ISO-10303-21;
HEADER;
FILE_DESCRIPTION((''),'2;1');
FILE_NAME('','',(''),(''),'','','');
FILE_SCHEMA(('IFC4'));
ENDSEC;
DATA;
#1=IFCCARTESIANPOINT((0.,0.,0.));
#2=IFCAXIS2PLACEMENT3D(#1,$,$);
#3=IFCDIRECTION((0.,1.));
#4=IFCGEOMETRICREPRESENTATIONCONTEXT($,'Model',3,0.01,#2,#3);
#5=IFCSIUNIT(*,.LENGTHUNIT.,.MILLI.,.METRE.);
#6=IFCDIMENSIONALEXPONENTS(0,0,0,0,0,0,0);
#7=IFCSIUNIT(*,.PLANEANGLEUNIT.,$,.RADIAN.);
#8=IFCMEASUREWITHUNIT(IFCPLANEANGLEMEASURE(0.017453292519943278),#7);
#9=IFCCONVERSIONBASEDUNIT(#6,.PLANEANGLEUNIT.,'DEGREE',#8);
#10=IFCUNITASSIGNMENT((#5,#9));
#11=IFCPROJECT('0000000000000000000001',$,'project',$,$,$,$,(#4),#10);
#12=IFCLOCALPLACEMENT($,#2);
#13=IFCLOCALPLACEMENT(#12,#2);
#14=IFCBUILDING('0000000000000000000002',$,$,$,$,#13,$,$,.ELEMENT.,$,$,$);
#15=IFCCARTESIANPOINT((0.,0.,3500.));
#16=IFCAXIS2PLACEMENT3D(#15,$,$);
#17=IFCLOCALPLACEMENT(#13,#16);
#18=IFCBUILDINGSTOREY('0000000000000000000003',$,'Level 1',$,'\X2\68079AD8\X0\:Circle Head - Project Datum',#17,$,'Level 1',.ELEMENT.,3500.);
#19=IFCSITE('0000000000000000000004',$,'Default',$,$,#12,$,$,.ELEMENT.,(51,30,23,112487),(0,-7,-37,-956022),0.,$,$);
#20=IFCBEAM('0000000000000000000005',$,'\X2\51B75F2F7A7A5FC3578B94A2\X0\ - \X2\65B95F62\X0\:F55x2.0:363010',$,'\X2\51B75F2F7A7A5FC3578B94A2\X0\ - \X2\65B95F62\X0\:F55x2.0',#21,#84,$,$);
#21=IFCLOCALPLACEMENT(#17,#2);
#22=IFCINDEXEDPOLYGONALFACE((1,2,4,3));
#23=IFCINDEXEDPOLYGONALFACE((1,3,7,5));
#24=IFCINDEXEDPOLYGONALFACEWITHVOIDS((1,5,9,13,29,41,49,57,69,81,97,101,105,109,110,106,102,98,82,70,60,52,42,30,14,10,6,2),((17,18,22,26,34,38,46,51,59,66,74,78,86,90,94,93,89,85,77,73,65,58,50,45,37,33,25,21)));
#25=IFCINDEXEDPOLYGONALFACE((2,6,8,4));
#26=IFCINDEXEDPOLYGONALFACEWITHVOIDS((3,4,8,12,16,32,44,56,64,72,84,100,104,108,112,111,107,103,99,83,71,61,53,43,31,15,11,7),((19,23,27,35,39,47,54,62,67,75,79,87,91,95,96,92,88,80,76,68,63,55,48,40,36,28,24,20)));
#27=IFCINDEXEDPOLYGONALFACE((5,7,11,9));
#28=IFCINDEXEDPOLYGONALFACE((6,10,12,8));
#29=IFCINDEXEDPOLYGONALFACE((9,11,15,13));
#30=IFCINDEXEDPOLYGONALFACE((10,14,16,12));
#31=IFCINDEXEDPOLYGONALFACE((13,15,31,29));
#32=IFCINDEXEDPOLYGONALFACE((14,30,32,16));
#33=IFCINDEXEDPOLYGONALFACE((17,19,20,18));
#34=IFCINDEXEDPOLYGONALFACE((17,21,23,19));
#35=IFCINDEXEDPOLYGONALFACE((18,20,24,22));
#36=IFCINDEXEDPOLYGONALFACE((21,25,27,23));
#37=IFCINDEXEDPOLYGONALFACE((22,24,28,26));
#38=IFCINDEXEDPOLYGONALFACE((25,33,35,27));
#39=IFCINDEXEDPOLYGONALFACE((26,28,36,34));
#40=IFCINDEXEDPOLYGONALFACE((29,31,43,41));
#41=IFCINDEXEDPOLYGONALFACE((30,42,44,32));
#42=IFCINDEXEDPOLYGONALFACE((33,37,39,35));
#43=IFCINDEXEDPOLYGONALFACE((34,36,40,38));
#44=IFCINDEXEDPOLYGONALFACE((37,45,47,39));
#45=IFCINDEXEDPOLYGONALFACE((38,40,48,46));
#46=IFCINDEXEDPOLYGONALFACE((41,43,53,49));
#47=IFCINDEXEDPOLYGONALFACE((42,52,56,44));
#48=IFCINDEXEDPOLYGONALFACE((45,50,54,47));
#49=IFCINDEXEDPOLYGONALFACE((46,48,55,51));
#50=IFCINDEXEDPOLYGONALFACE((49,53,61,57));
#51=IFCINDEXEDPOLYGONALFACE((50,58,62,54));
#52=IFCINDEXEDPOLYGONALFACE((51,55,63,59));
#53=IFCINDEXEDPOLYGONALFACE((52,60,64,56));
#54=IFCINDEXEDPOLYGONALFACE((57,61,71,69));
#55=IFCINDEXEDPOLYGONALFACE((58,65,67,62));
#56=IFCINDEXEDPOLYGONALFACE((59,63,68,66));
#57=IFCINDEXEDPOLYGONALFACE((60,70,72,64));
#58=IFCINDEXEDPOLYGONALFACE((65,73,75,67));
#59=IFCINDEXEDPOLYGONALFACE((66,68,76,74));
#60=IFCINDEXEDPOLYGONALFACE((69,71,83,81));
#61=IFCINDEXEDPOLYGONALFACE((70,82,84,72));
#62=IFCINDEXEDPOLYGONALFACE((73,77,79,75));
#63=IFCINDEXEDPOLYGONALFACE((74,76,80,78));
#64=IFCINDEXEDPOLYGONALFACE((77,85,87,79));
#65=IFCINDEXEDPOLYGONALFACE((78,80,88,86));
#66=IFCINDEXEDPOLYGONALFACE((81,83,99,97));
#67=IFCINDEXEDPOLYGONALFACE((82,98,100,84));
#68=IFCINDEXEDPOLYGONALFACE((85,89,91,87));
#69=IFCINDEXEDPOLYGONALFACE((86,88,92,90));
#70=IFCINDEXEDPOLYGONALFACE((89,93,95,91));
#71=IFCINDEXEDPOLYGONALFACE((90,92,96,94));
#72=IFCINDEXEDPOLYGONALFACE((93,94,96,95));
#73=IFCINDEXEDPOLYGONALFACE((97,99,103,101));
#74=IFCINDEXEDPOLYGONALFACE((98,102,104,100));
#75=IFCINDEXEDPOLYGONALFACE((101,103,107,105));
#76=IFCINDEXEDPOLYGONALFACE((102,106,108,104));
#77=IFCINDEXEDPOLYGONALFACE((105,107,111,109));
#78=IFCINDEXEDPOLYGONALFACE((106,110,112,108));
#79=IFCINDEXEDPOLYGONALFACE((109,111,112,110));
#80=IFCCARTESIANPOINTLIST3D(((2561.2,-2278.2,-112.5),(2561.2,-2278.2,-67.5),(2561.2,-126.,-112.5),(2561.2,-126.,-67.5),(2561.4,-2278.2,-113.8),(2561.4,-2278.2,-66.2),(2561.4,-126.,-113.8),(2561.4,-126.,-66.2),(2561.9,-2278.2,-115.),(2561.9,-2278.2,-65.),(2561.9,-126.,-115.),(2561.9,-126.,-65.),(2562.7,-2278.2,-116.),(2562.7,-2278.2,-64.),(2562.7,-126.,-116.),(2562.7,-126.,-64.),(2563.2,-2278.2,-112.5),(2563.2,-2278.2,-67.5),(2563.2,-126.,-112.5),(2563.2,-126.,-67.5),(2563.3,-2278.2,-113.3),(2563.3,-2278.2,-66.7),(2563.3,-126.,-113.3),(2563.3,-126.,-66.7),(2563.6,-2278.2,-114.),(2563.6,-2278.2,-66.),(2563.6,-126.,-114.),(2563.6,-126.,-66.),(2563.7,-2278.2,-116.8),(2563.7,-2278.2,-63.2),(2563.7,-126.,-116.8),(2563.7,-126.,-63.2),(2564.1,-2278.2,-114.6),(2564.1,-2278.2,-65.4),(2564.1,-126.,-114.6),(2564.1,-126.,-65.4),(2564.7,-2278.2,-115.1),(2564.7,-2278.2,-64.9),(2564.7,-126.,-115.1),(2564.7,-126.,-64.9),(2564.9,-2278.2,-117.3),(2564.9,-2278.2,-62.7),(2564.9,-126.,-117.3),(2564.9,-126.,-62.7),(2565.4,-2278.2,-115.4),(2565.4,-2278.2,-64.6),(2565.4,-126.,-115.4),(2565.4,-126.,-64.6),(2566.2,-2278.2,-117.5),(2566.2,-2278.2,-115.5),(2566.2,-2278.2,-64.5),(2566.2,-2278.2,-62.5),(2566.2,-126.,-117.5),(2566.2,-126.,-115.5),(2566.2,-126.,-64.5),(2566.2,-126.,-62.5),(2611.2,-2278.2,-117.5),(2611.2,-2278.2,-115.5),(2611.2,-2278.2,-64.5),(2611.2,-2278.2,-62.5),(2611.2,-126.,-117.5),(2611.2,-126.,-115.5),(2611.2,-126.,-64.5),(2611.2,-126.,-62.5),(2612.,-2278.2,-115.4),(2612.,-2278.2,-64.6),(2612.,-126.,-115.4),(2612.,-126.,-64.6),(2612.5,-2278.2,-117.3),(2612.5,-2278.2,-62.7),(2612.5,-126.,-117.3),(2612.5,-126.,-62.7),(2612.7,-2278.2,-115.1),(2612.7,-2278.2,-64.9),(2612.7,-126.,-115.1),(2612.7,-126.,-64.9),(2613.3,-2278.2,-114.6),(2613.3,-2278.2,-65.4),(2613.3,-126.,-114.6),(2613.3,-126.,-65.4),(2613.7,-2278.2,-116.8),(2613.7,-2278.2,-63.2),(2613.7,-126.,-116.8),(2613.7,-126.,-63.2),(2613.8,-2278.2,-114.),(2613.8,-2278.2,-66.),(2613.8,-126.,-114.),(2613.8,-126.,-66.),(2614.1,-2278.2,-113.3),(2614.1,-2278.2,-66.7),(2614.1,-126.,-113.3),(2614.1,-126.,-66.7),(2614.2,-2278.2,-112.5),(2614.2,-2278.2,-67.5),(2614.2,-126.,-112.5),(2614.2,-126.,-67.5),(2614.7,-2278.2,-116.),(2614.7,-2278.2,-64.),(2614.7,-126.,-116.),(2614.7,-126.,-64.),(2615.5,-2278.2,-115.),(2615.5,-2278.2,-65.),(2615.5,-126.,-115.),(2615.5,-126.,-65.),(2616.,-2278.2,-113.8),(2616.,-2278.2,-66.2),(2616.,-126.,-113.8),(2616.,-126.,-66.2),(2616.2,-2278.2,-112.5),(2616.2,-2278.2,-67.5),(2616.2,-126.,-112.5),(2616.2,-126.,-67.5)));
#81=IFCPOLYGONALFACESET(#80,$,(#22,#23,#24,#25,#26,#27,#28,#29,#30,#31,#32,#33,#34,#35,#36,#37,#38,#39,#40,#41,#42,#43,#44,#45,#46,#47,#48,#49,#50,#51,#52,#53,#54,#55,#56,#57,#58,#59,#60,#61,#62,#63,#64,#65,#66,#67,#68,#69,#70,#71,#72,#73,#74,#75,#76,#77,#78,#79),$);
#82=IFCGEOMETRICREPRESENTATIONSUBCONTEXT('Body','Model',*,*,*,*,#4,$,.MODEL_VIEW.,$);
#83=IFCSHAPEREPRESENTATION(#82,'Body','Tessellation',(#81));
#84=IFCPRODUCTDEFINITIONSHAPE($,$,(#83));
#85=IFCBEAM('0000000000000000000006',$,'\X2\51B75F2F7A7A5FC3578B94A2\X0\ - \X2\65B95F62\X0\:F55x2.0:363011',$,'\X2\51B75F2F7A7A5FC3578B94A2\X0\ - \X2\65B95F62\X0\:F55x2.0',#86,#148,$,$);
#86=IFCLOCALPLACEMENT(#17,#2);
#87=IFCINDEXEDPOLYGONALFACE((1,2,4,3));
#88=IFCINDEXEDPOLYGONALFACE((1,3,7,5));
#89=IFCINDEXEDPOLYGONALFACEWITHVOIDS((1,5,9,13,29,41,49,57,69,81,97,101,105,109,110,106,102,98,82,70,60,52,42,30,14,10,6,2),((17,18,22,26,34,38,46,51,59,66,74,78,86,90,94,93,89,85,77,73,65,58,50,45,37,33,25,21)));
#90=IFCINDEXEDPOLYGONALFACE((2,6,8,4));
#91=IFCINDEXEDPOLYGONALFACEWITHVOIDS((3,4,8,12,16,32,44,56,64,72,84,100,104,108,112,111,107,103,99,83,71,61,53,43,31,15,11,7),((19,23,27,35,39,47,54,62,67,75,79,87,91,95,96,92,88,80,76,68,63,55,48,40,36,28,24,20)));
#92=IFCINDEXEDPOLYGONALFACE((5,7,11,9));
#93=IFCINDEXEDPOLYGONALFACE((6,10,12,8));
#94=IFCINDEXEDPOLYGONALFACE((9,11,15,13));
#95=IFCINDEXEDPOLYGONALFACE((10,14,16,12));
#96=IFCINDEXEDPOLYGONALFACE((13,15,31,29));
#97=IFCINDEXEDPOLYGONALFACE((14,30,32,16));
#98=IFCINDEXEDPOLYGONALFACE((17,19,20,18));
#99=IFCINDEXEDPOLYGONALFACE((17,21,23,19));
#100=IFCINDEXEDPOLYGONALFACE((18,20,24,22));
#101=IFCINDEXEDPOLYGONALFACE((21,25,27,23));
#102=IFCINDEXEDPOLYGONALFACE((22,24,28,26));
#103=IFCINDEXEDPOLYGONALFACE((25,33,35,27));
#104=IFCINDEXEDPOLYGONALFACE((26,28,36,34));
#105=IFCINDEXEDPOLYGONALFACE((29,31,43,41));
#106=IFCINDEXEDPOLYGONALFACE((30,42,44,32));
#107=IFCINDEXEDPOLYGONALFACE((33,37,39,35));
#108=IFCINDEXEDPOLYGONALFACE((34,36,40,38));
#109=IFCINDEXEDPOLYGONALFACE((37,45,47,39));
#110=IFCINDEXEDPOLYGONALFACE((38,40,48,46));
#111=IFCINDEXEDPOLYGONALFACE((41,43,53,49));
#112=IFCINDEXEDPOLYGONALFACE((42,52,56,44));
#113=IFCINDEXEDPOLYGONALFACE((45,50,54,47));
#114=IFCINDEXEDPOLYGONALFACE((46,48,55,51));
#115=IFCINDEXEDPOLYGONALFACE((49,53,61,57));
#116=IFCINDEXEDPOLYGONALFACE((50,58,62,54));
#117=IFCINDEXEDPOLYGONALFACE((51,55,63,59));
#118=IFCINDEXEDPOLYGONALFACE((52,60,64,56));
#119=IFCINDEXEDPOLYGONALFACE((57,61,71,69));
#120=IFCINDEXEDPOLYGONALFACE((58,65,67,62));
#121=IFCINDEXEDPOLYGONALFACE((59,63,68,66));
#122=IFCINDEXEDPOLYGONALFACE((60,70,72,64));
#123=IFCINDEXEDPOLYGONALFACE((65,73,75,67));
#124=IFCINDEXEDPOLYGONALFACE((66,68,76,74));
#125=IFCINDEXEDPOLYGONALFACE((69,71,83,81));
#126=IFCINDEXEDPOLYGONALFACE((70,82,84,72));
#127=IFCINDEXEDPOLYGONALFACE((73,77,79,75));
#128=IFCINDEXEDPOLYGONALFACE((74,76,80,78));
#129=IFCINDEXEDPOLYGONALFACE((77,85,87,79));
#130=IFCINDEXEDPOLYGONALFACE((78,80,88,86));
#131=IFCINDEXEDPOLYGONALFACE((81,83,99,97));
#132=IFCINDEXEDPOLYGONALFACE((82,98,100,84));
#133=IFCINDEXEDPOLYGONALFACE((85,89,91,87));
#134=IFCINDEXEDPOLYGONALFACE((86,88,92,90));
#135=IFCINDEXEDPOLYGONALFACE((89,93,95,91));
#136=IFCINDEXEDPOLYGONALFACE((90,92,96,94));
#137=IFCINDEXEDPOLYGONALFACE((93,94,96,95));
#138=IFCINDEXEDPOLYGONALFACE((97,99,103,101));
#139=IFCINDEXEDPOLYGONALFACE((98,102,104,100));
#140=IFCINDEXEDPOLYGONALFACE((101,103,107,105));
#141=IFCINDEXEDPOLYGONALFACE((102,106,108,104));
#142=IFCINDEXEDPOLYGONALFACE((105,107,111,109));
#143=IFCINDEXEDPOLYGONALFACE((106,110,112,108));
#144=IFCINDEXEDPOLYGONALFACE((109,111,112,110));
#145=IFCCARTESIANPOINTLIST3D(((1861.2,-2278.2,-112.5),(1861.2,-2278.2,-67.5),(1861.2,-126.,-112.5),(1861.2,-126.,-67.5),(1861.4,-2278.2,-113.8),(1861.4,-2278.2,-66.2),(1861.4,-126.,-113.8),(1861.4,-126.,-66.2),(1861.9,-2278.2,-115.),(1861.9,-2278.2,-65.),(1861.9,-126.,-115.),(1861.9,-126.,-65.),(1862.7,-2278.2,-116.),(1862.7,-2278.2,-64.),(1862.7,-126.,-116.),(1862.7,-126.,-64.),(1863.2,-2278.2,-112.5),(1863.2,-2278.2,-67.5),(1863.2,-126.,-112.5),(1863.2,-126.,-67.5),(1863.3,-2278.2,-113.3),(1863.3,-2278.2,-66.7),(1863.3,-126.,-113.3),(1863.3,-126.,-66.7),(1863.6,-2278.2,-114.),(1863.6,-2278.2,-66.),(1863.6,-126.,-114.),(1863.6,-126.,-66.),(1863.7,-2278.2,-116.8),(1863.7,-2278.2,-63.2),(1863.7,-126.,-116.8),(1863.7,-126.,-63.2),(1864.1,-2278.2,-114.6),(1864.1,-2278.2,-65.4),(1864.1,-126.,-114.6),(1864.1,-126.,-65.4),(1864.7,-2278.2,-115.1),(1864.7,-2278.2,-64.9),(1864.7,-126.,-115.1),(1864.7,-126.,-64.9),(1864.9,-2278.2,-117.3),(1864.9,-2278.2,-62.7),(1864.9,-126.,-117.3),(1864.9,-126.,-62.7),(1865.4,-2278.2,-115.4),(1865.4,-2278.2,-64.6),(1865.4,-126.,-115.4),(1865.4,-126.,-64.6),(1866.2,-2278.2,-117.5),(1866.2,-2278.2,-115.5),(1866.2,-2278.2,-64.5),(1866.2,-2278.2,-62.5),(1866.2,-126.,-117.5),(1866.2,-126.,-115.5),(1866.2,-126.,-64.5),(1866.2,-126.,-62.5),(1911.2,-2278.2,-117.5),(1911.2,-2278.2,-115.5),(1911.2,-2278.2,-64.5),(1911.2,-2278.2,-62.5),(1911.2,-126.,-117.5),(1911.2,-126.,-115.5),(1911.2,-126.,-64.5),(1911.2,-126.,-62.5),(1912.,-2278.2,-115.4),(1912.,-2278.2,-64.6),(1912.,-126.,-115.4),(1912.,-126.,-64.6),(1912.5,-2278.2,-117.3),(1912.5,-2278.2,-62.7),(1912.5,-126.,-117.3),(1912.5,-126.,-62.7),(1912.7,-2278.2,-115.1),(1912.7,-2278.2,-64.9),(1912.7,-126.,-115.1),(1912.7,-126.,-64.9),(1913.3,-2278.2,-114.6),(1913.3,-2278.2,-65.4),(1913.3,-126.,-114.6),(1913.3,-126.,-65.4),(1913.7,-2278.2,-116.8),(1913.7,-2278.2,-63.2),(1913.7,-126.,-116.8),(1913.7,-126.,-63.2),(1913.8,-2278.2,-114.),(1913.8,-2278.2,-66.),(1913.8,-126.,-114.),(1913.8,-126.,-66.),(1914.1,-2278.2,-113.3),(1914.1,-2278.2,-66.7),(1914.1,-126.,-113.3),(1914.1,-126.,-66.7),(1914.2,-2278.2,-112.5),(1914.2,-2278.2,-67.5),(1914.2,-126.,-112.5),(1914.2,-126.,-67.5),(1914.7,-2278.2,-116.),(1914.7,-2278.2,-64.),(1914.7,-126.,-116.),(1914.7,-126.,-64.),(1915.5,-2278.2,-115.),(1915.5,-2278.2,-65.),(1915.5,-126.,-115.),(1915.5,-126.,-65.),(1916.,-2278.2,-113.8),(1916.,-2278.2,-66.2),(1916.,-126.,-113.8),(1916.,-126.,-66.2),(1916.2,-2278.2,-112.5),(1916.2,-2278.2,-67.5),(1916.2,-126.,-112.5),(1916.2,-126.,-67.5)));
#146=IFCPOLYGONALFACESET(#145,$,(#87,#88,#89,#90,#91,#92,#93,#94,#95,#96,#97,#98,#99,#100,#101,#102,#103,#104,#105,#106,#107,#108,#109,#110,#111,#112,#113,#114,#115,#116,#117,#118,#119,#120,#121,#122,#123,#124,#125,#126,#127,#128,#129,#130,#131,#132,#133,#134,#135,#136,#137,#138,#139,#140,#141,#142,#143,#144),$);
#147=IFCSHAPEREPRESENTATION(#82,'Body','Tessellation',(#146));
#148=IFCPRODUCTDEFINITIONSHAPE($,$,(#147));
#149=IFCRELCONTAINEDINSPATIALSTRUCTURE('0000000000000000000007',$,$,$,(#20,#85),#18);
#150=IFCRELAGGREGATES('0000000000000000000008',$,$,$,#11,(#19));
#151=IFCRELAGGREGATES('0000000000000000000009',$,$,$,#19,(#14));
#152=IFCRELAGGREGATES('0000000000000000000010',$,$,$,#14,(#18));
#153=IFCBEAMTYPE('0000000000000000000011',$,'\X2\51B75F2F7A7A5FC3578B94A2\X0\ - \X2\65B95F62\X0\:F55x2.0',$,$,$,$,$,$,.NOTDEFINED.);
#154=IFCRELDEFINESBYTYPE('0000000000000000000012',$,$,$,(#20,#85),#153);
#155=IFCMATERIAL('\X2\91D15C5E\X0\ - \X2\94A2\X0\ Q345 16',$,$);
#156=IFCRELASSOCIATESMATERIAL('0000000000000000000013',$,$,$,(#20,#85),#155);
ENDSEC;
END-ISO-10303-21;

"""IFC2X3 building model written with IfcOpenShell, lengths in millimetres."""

from ifc_helpers import new_model, entity, si_unit, converted_unit, direction, frame, frame_2d, origin, place, context, subcontext, project, spatial, polyline, circle_curve, parameter, trimmed, segment, composite_curve, outline, extrude, material, type_object, element, save


model = new_model("IFC2X3")

# Units and contexts
model_context = context("Model", 3, precision=0.01, world=origin(), true_north=direction((0.0, 1.0)))
body_context = subcontext(model_context, "Body", "Model", "MODEL_VIEW")
ifc_project = project(units=[si_unit("LENGTHUNIT", "METRE", prefix="MILLI"), converted_unit("PLANEANGLEUNIT", "DEGREE", entity("IfcPlaneAngleMeasure", 0.017453292519943278), si_unit("PLANEANGLEUNIT", "RADIAN"), dimensions=[0, 0, 0, 0, 0, 0, 0])], contexts=[model_context])

# Site, building, storey
site_placement = place(None, origin())
site = spatial("IfcSite", under=ifc_project, at=site_placement, Name="Default", CompositionType="ELEMENT", RefLatitude=(51, 30, 23, 112487), RefLongitude=(0, -7, -37, -956022), RefElevation=0.0)
building_placement = place(site_placement, origin())
building = spatial("IfcBuilding", under=site, at=building_placement, CompositionType="ELEMENT")
storey_placement = place(building_placement, frame((0.0, 0.0, 3500.0)))
storey = spatial("IfcBuildingStorey", under=building, at=storey_placement, Name="Level 1", ObjectType="标高:Circle Head - Project Datum", LongName="Level 1", CompositionType="ELEMENT", Elevation=3500.0)

# Beams
ifc_material_1 = material(Name="金属 - 钢 Q345 16")
beam_type_1 = type_object("IfcBeamType", Name="冷弯空心型钢 - 方形:F55x2.0", PredefinedType="NOTDEFINED")
beam_1_placement = place(storey_placement, frame((2588.7, -390.5, -62.5), z_axis=(0.0, 0.0, 1.0), x_axis=(0.0, -1.0, 0.0)))
element("IfcBeam", 1, at=beam_1_placement, inside=storey, type_object=beam_type_1, material=ifc_material_1, Name="冷弯空心型钢 - 方形:F55x2.0:363010", ObjectType="冷弯空心型钢 - 方形:F55x2.0", context=body_context, shape_type="SweptSolid", body=[
    extrude(outline(composite_curve([segment(trimmed(circle_curve(frame_2d((-22.5, 22.5), x_axis=(1.0, 0.0)), 5.0), [parameter(90.0)], [parameter(180.0)], True, "PARAMETER"), True, "CONTINUOUS"), segment(polyline([(-27.5, 22.5), (-27.5, -22.5)]), True, "CONTINUOUS"), segment(trimmed(circle_curve(frame_2d((-22.5, -22.5), x_axis=(1.0, 0.0)), 5.0), [parameter(180.0)], [parameter(270.0)], True, "PARAMETER"), True, "CONTINUOUS"), segment(polyline([(-22.5, -27.5), (22.5, -27.5)]), True, "CONTINUOUS"), segment(trimmed(circle_curve(frame_2d((22.5, -22.5), x_axis=(1.0, 0.0)), 5.0), [parameter(270.0)], [parameter(0.0)], True, "PARAMETER"), True, "CONTINUOUS"), segment(polyline([(27.5, -22.5), (27.5, 22.5)]), True, "CONTINUOUS"), segment(trimmed(circle_curve(frame_2d((22.5, 22.5), x_axis=(1.0, 0.0)), 5.0), [parameter(0.0)], [parameter(90.0)], True, "PARAMETER"), True, "CONTINUOUS"), segment(polyline([(22.5, 27.5), (-22.5, 27.5)]), True, "CONTINUOUS")], self_intersect=False), holes=[composite_curve([segment(polyline([(-22.5, 25.5), (22.5, 25.5)]), True, "CONTINUOUS"), segment(trimmed(circle_curve(frame_2d((22.5, 22.5), x_axis=(1.0, 0.0)), 3.0), [parameter(0.0)], [parameter(90.0)], True, "PARAMETER"), False, "CONTINUOUS"), segment(polyline([(25.5, 22.5), (25.5, -22.5)]), True, "CONTINUOUS"), segment(trimmed(circle_curve(frame_2d((22.5, -22.5), x_axis=(1.0, 0.0)), 3.0), [parameter(270.0)], [parameter(360.0)], True, "PARAMETER"), False, "CONTINUOUS"), segment(polyline([(22.5, -25.5), (-22.5, -25.5)]), True, "CONTINUOUS"), segment(trimmed(circle_curve(frame_2d((-22.5, -22.5), x_axis=(1.0, 0.0)), 3.0), [parameter(180.0)], [parameter(270.0)], True, "PARAMETER"), False, "CONTINUOUS"), segment(polyline([(-25.5, -22.5), (-25.5, 22.5)]), True, "CONTINUOUS"), segment(trimmed(circle_curve(frame_2d((-22.5, 22.5), x_axis=(1.0, 0.0)), 3.0), [parameter(90.0)], [parameter(180.0)], True, "PARAMETER"), False, "CONTINUOUS")], self_intersect=False)]), frame((-264.5, 0.0, -27.5), z_axis=(1.0, 0.0, 0.0), x_axis=(0.0, 1.0, 0.0)), (0.0, 0.0, 1.0), 2152.2),
])
beam_2_placement = place(storey_placement, frame((1888.7, -390.5, -62.5), z_axis=(0.0, 0.0, 1.0), x_axis=(0.0, -1.0, 0.0)))
element("IfcBeam", 2, at=beam_2_placement, inside=storey, type_object=beam_type_1, material=ifc_material_1, Name="冷弯空心型钢 - 方形:F55x2.0:363011", ObjectType="冷弯空心型钢 - 方形:F55x2.0", context=body_context, shape_type="SweptSolid", body=[
    extrude(outline(composite_curve([segment(trimmed(circle_curve(frame_2d((-22.5, 22.5), x_axis=(1.0, 0.0)), 5.0), [parameter(90.0)], [parameter(180.0)], True, "PARAMETER"), True, "CONTINUOUS"), segment(polyline([(-27.5, 22.5), (-27.5, -22.5)]), True, "CONTINUOUS"), segment(trimmed(circle_curve(frame_2d((-22.5, -22.5), x_axis=(1.0, 0.0)), 5.0), [parameter(180.0)], [parameter(270.0)], True, "PARAMETER"), True, "CONTINUOUS"), segment(polyline([(-22.5, -27.5), (22.5, -27.5)]), True, "CONTINUOUS"), segment(trimmed(circle_curve(frame_2d((22.5, -22.5), x_axis=(1.0, 0.0)), 5.0), [parameter(270.0)], [parameter(0.0)], True, "PARAMETER"), True, "CONTINUOUS"), segment(polyline([(27.5, -22.5), (27.5, 22.5)]), True, "CONTINUOUS"), segment(trimmed(circle_curve(frame_2d((22.5, 22.5), x_axis=(1.0, 0.0)), 5.0), [parameter(0.0)], [parameter(90.0)], True, "PARAMETER"), True, "CONTINUOUS"), segment(polyline([(22.5, 27.5), (-22.5, 27.5)]), True, "CONTINUOUS")], self_intersect=False), holes=[composite_curve([segment(polyline([(-22.5, 25.5), (22.5, 25.5)]), True, "CONTINUOUS"), segment(trimmed(circle_curve(frame_2d((22.5, 22.5), x_axis=(1.0, 0.0)), 3.0), [parameter(0.0)], [parameter(90.0)], True, "PARAMETER"), False, "CONTINUOUS"), segment(polyline([(25.5, 22.5), (25.5, -22.5)]), True, "CONTINUOUS"), segment(trimmed(circle_curve(frame_2d((22.5, -22.5), x_axis=(1.0, 0.0)), 3.0), [parameter(270.0)], [parameter(360.0)], True, "PARAMETER"), False, "CONTINUOUS"), segment(polyline([(22.5, -25.5), (-22.5, -25.5)]), True, "CONTINUOUS"), segment(trimmed(circle_curve(frame_2d((-22.5, -22.5), x_axis=(1.0, 0.0)), 3.0), [parameter(180.0)], [parameter(270.0)], True, "PARAMETER"), False, "CONTINUOUS"), segment(polyline([(-25.5, -22.5), (-25.5, 22.5)]), True, "CONTINUOUS"), segment(trimmed(circle_curve(frame_2d((-22.5, 22.5), x_axis=(1.0, 0.0)), 3.0), [parameter(90.0)], [parameter(180.0)], True, "PARAMETER"), False, "CONTINUOUS")], self_intersect=False)]), frame((-264.5, 0.0, -27.5), z_axis=(1.0, 0.0, 0.0), x_axis=(0.0, 1.0, 0.0)), (0.0, 0.0, 1.0), 2152.2),
])

save(model, "model.ifc")
